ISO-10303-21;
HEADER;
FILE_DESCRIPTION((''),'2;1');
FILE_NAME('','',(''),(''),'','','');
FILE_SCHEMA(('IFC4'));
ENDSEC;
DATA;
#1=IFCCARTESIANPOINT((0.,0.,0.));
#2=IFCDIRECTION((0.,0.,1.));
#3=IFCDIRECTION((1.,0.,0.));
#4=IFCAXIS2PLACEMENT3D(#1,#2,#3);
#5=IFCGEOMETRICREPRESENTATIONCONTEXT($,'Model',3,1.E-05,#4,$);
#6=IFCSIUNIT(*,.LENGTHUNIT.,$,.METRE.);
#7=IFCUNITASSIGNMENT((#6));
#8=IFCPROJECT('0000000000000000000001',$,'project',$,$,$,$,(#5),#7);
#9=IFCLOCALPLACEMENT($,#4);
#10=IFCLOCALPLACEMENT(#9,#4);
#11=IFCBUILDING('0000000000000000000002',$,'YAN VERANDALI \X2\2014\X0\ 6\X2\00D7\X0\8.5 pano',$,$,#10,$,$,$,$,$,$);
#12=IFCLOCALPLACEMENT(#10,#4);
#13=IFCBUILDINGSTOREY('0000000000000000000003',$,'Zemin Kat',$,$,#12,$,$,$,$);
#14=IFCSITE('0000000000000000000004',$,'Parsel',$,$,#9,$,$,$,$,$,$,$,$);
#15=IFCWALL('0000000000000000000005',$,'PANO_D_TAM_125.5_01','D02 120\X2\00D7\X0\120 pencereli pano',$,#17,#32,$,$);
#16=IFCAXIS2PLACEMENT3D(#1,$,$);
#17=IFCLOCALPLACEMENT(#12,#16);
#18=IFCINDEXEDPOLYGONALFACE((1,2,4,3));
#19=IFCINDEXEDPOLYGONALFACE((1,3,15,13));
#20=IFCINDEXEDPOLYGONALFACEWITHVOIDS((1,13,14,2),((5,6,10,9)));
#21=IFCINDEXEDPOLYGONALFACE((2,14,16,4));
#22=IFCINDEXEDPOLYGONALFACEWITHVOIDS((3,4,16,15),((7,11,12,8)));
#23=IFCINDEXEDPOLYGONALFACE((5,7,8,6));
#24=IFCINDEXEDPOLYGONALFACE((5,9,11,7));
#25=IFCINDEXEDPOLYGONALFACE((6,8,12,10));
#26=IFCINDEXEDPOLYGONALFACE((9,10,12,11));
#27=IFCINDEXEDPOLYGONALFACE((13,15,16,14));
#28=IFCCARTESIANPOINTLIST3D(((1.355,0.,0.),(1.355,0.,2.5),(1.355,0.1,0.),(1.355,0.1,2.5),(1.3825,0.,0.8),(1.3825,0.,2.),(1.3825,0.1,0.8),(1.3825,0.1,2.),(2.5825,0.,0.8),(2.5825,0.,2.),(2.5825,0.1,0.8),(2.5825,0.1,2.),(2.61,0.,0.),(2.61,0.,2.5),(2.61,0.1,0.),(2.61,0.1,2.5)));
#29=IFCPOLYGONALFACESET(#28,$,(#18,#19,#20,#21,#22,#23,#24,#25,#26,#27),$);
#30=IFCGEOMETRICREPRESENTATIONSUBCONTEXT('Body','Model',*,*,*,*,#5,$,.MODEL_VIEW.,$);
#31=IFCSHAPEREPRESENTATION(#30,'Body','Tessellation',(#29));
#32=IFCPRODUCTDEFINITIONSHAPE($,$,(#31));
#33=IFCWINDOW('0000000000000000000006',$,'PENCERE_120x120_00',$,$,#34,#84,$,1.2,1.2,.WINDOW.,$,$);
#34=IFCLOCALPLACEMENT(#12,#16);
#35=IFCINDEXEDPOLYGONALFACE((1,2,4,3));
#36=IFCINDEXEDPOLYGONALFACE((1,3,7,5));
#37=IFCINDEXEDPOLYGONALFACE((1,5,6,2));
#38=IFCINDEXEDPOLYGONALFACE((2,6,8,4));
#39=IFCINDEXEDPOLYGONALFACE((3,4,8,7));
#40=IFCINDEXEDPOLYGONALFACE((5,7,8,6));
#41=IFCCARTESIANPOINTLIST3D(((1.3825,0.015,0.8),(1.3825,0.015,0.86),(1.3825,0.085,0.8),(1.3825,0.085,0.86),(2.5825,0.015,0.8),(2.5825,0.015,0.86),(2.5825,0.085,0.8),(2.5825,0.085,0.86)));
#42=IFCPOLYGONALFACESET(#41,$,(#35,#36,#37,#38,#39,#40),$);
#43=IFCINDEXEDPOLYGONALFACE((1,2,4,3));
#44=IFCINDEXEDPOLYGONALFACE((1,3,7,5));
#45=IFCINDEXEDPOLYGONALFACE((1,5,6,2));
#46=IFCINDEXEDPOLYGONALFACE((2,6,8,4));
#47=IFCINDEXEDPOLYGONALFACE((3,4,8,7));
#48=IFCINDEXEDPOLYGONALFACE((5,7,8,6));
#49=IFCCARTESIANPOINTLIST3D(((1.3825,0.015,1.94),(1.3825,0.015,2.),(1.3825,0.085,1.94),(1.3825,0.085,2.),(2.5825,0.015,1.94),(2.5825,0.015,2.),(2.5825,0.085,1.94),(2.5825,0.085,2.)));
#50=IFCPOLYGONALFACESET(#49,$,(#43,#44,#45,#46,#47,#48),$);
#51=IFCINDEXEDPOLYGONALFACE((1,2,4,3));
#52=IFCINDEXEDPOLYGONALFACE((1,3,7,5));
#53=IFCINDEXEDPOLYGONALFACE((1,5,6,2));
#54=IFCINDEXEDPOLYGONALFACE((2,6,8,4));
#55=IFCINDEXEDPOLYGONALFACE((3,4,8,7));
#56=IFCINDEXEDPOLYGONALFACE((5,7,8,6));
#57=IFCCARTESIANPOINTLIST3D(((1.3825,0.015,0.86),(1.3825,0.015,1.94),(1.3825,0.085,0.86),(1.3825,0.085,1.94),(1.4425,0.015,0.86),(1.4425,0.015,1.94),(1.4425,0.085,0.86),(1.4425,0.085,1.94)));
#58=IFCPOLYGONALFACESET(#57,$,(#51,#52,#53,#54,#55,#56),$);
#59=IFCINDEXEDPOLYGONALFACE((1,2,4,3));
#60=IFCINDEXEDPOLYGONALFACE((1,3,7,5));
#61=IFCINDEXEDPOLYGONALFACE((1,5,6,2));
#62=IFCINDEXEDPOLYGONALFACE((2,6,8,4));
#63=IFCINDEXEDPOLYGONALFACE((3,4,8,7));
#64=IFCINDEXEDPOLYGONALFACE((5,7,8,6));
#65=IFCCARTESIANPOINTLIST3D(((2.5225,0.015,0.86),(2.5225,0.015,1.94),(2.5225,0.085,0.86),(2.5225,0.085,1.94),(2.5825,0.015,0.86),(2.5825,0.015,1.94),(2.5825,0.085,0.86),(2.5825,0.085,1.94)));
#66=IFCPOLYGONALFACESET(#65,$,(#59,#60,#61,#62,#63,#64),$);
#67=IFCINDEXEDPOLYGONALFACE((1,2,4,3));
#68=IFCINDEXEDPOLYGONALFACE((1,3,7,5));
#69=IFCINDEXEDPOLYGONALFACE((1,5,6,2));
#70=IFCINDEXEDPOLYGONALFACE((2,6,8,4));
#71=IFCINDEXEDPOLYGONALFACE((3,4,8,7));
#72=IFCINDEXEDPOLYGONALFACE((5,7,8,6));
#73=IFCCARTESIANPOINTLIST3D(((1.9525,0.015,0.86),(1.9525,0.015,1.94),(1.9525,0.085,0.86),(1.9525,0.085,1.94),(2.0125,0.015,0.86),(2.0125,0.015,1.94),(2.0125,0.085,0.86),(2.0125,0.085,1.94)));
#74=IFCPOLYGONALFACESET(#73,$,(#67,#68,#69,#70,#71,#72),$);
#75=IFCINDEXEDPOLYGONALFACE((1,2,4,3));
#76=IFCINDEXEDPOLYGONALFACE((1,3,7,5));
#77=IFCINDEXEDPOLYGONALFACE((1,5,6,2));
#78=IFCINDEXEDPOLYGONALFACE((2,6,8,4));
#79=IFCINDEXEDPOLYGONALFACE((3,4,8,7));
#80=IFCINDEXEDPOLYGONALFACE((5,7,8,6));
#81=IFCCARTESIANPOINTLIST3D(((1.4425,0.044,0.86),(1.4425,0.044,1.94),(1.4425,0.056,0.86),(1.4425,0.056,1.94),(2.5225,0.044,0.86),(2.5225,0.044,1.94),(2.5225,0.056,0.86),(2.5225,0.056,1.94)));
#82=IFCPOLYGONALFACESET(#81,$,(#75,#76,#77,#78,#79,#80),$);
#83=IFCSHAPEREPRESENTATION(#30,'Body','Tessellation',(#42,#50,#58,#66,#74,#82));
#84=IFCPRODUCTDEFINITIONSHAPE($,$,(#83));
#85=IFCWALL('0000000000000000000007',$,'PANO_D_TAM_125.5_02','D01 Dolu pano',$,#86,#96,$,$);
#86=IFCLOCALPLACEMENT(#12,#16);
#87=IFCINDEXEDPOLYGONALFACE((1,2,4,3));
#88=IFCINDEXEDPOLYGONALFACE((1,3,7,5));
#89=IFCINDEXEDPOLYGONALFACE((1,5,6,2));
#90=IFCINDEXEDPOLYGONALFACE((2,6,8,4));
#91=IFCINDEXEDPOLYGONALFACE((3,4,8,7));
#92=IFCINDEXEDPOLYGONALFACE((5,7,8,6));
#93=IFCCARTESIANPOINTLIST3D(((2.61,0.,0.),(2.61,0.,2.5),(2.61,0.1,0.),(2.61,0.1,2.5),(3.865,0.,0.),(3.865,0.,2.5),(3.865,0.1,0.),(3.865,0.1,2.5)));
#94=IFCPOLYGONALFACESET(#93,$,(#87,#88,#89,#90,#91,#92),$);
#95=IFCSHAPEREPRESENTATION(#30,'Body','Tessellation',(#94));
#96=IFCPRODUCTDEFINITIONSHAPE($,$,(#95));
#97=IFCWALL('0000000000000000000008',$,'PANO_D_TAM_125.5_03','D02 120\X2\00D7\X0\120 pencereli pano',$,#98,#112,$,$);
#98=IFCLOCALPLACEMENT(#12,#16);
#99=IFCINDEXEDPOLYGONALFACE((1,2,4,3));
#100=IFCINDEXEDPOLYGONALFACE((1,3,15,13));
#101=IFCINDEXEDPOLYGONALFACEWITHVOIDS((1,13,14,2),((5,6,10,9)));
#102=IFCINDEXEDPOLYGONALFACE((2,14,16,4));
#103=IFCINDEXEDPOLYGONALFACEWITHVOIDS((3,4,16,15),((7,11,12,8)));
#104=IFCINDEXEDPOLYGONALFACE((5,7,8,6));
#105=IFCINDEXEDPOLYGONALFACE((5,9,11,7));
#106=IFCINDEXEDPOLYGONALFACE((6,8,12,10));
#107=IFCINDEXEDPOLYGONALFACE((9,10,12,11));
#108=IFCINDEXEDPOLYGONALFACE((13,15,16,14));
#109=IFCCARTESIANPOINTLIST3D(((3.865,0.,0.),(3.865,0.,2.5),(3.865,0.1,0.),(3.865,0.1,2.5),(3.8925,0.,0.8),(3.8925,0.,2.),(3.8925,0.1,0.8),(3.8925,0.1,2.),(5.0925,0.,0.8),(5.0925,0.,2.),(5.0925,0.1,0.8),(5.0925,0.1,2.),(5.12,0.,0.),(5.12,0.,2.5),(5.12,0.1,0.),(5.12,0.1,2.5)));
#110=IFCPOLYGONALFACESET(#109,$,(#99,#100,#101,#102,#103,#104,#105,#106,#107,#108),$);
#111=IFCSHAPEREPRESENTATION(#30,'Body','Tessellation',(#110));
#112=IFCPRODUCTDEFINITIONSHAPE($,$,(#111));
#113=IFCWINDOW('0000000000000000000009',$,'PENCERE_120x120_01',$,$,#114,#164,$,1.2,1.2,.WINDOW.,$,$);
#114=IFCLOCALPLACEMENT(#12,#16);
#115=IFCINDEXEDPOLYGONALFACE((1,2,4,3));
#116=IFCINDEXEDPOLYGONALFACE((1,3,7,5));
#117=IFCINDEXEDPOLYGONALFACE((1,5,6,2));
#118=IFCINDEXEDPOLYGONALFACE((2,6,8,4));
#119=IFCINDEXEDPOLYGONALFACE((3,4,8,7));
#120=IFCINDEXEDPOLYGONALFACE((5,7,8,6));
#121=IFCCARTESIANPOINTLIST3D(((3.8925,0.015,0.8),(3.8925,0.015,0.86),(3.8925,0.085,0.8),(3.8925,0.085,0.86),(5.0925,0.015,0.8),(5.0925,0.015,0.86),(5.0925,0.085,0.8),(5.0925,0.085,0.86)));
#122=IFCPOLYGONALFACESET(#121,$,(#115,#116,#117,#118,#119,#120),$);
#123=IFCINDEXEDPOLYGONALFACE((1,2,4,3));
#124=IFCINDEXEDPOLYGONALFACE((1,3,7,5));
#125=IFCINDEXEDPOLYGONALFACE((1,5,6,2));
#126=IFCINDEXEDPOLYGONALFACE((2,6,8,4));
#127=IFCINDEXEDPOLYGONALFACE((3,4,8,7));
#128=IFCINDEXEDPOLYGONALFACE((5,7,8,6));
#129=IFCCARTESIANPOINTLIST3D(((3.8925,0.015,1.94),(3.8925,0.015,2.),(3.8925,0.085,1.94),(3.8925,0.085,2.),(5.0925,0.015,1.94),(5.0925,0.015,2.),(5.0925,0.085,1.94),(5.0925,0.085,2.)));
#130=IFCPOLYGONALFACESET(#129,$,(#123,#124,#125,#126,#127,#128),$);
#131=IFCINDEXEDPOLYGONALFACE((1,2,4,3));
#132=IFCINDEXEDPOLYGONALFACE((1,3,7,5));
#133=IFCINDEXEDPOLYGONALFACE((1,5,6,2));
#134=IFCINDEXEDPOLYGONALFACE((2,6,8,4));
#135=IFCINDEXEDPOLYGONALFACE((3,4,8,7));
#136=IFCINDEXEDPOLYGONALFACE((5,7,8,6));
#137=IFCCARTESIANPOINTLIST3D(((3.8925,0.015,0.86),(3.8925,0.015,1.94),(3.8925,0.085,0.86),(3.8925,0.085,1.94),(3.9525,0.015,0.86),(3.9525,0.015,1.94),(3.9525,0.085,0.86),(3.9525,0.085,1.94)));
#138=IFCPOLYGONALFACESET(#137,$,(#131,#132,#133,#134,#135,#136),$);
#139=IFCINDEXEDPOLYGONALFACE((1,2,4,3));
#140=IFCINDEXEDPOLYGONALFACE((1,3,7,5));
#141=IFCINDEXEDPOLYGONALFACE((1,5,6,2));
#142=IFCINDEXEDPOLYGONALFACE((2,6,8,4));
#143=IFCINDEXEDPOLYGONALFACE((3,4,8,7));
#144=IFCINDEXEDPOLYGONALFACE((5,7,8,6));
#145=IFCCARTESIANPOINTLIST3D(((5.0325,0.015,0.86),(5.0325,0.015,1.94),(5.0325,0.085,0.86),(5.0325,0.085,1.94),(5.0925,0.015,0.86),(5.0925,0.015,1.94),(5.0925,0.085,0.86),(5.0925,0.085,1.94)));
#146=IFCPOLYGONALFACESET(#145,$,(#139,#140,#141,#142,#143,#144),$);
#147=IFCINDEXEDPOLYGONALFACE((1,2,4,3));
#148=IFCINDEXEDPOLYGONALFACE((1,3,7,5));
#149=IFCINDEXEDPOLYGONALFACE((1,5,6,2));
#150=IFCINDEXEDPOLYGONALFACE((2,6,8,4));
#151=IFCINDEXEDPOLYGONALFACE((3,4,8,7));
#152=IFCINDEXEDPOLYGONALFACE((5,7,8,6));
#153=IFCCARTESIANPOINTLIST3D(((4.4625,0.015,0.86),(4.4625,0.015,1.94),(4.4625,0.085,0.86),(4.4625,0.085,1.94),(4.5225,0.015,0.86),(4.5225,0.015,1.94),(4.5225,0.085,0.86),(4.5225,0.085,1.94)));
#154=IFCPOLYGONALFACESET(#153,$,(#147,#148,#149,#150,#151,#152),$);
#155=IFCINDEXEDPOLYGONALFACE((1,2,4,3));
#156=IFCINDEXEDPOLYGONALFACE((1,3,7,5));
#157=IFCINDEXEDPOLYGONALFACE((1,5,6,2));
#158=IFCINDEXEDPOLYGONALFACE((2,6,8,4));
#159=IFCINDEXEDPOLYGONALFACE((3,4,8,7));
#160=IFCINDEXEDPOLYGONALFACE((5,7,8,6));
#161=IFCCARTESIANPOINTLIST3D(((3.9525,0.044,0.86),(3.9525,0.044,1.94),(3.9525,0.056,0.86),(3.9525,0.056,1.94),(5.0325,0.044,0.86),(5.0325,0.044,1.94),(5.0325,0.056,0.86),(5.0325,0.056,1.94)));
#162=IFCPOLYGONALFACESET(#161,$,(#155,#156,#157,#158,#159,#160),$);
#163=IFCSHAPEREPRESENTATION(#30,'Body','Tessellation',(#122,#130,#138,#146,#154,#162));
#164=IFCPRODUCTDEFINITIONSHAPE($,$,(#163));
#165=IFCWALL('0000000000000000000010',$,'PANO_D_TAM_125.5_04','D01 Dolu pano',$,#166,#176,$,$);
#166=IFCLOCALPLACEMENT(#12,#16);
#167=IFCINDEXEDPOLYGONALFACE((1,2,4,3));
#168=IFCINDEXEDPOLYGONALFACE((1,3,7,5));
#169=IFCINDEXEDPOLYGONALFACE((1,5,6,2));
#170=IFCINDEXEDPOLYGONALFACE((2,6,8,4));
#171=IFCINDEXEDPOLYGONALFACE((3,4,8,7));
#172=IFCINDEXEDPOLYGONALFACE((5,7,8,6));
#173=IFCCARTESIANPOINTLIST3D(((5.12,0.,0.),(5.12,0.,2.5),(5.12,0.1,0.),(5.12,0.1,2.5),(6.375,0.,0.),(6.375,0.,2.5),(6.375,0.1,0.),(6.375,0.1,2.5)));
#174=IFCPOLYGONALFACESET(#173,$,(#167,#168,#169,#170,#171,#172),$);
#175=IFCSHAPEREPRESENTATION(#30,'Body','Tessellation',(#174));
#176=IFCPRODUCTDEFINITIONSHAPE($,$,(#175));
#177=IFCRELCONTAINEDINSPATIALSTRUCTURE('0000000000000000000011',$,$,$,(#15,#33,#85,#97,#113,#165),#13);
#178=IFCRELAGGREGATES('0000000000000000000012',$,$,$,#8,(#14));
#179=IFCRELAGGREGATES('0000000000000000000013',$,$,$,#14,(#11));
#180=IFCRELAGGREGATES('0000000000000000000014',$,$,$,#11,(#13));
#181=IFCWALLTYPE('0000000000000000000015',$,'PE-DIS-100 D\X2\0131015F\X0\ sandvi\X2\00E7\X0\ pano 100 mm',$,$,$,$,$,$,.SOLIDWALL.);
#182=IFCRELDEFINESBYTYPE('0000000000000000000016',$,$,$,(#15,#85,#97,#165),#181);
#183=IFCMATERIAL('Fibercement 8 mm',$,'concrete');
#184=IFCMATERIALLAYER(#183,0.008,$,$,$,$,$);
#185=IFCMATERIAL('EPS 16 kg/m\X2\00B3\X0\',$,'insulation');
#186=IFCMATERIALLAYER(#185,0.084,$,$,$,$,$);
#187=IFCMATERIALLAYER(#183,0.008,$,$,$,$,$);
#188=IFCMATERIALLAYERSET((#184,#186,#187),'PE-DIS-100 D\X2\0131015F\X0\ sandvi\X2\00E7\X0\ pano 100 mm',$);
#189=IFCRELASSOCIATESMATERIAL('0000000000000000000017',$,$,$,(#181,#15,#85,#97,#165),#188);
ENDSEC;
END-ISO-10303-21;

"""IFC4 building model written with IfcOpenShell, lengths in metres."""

from ifc_helpers import new_model, si_unit, frame, origin_with_axes, place, context, subcontext, project, spatial, line, indexed_curve, outline, extrude, material, layer, layer_set, layer_usage, type_object, element, fill, save


model = new_model("IFC4")

# Units and contexts
model_context = context("Model", 3, precision=1e-05, world=origin_with_axes())
body_context = subcontext(model_context, "Body", "Model", "MODEL_VIEW")
ifc_project = project(units=[si_unit("LENGTHUNIT", "METRE")], contexts=[model_context])

# Site, building, storey
site_placement = place(None, origin_with_axes())
site = spatial("IfcSite", under=ifc_project, at=site_placement, Name="Parsel")
building_placement = place(site_placement, origin_with_axes())
building = spatial("IfcBuilding", under=site, at=building_placement, Name="YAN VERANDALI — 6×8.5 pano")
storey_placement = place(building_placement, origin_with_axes())
storey = spatial("IfcBuildingStorey", under=building, at=storey_placement, Name="Zemin Kat")

# Shared definitions
ifc_material_1 = material(Name="Fibercement 8 mm", Category="concrete")
ifc_layer_1 = layer(ifc_material_1, 0.008)
ifc_material_2 = material(Name="EPS 16 kg/m³", Category="insulation")
ifc_layer_2 = layer(ifc_material_2, 0.084)
ifc_layer_3 = layer(ifc_material_1, 0.008)
ifc_layer_set = layer_set([ifc_layer_1, ifc_layer_2, ifc_layer_3], Name="PE-DIS-100 Dış sandviç pano 100 mm")
wall_type = type_object("IfcWallType", Name="PE-DIS-100 Dış sandviç pano 100 mm", PredefinedType="SOLIDWALL", material=ifc_layer_set)

# Wall, opening, window
ifc_layer_usage_1 = layer_usage(ifc_layer_set, "AXIS2", "POSITIVE", 0.0)
wall_1_placement = place(storey_placement, frame((1.355, 0.0, 0.0), z_axis=(0.0, 0.0, 1.0), x_axis=(1.0, 0.0, 0.0)))
wall_1 = element("IfcWall", 1, at=wall_1_placement, inside=storey, type_object=wall_type, material=ifc_layer_usage_1, Name="PANO_D_TAM_125.5_01", Description="D02 120×120 pencereli pano", context=body_context, shape_type="SweptSolid", body=[
    extrude(outline(indexed_curve([(0.0, 0.0), (1.255, 0.0), (1.255, 0.1), (0.0, 0.1)], segments=[line(1, 2, 3, 4, 1)])), origin_with_axes(), (0.0, 0.0, 1.0), 2.5),
])
opening_1_placement = place(wall_1_placement, origin_with_axes())
opening_1 = element("IfcOpeningElement", 2, at=opening_1_placement, cuts=wall_1, PredefinedType="OPENING", context=body_context, shape_type="SweptSolid", body=[
    extrude(outline(indexed_curve([(0.0, 0.0), (1.2, 0.0), (1.2, 0.14), (0.0, 0.14)], segments=[line(1, 2, 3, 4, 1)])), frame((0.0275, -0.02, 0.8), z_axis=(0.0, 0.0, 1.0), x_axis=(1.0, 0.0, 0.0)), (0.0, 0.0, 1.0), 1.2),
])
window_1_placement = place(storey_placement, frame((1.355, 0.0, 0.0), z_axis=(0.0, 0.0, 1.0), x_axis=(1.0, 0.0, 0.0)))
window_1 = element("IfcWindow", 3, at=window_1_placement, inside=storey, Name="PENCERE_120x120_00", OverallHeight=1.2, OverallWidth=1.2, PredefinedType="WINDOW", context=body_context, shape_type="SweptSolid", body=[
    extrude(outline(indexed_curve([(0.0, 0.0), (1.2, 0.0), (1.2, 0.07), (0.0, 0.07)], segments=[line(1, 2, 3, 4, 1)])), frame((0.0275, 0.015, 0.8), z_axis=(0.0, 0.0, 1.0), x_axis=(1.0, 0.0, 0.0)), (0.0, 0.0, 1.0), 0.06),
    extrude(outline(indexed_curve([(0.0, 0.0), (1.2, 0.0), (1.2, 0.07), (0.0, 0.07)], segments=[line(1, 2, 3, 4, 1)])), frame((0.0275, 0.015, 1.94), z_axis=(0.0, 0.0, 1.0), x_axis=(1.0, 0.0, 0.0)), (0.0, 0.0, 1.0), 0.06),
    extrude(outline(indexed_curve([(0.0, 0.0), (0.06, 0.0), (0.06, 0.07), (0.0, 0.07)], segments=[line(1, 2, 3, 4, 1)])), frame((0.0275, 0.015, 0.86), z_axis=(0.0, 0.0, 1.0), x_axis=(1.0, 0.0, 0.0)), (0.0, 0.0, 1.0), 1.08),
    extrude(outline(indexed_curve([(0.0, 0.0), (0.06, 0.0), (0.06, 0.07), (0.0, 0.07)], segments=[line(1, 2, 3, 4, 1)])), frame((1.1675, 0.015, 0.86), z_axis=(0.0, 0.0, 1.0), x_axis=(1.0, 0.0, 0.0)), (0.0, 0.0, 1.0), 1.08),
    extrude(outline(indexed_curve([(0.0, 0.0), (0.06, 0.0), (0.06, 0.07), (0.0, 0.07)], segments=[line(1, 2, 3, 4, 1)])), frame((0.5975, 0.015, 0.86), z_axis=(0.0, 0.0, 1.0), x_axis=(1.0, 0.0, 0.0)), (0.0, 0.0, 1.0), 1.08),
    extrude(outline(indexed_curve([(0.0, 0.0), (1.08, 0.0), (1.08, 0.012), (0.0, 0.012)], segments=[line(1, 2, 3, 4, 1)])), frame((0.0875, 0.044, 0.86), z_axis=(0.0, 0.0, 1.0), x_axis=(1.0, 0.0, 0.0)), (0.0, 0.0, 1.0), 1.08),
])
fill(opening_1, window_1)

# Wall
ifc_layer_usage_2 = layer_usage(ifc_layer_set, "AXIS2", "POSITIVE", 0.0)
wall_2_placement = place(storey_placement, frame((2.61, 0.0, 0.0), z_axis=(0.0, 0.0, 1.0), x_axis=(1.0, 0.0, 0.0)))
element("IfcWall", 4, at=wall_2_placement, inside=storey, type_object=wall_type, material=ifc_layer_usage_2, Name="PANO_D_TAM_125.5_02", Description="D01 Dolu pano", context=body_context, shape_type="SweptSolid", body=[
    extrude(outline(indexed_curve([(0.0, 0.0), (1.255, 0.0), (1.255, 0.1), (0.0, 0.1)], segments=[line(1, 2, 3, 4, 1)])), origin_with_axes(), (0.0, 0.0, 1.0), 2.5),
])

# Wall, opening, window
ifc_layer_usage_3 = layer_usage(ifc_layer_set, "AXIS2", "POSITIVE", 0.0)
wall_3_placement = place(storey_placement, frame((3.865, 0.0, 0.0), z_axis=(0.0, 0.0, 1.0), x_axis=(1.0, 0.0, 0.0)))
wall_3 = element("IfcWall", 5, at=wall_3_placement, inside=storey, type_object=wall_type, material=ifc_layer_usage_3, Name="PANO_D_TAM_125.5_03", Description="D02 120×120 pencereli pano", context=body_context, shape_type="SweptSolid", body=[
    extrude(outline(indexed_curve([(0.0, 0.0), (1.255, 0.0), (1.255, 0.1), (0.0, 0.1)], segments=[line(1, 2, 3, 4, 1)])), origin_with_axes(), (0.0, 0.0, 1.0), 2.5),
])
opening_2_placement = place(wall_3_placement, origin_with_axes())
opening_2 = element("IfcOpeningElement", 6, at=opening_2_placement, cuts=wall_3, PredefinedType="OPENING", context=body_context, shape_type="SweptSolid", body=[
    extrude(outline(indexed_curve([(0.0, 0.0), (1.2, 0.0), (1.2, 0.14), (0.0, 0.14)], segments=[line(1, 2, 3, 4, 1)])), frame((0.0275, -0.02, 0.8), z_axis=(0.0, 0.0, 1.0), x_axis=(1.0, 0.0, 0.0)), (0.0, 0.0, 1.0), 1.2),
])
window_2_placement = place(storey_placement, frame((3.865, 0.0, 0.0), z_axis=(0.0, 0.0, 1.0), x_axis=(1.0, 0.0, 0.0)))
window_2 = element("IfcWindow", 7, at=window_2_placement, inside=storey, Name="PENCERE_120x120_01", OverallHeight=1.2, OverallWidth=1.2, PredefinedType="WINDOW", context=body_context, shape_type="SweptSolid", body=[
    extrude(outline(indexed_curve([(0.0, 0.0), (1.2, 0.0), (1.2, 0.07), (0.0, 0.07)], segments=[line(1, 2, 3, 4, 1)])), frame((0.0275, 0.015, 0.8), z_axis=(0.0, 0.0, 1.0), x_axis=(1.0, 0.0, 0.0)), (0.0, 0.0, 1.0), 0.06),
    extrude(outline(indexed_curve([(0.0, 0.0), (1.2, 0.0), (1.2, 0.07), (0.0, 0.07)], segments=[line(1, 2, 3, 4, 1)])), frame((0.0275, 0.015, 1.94), z_axis=(0.0, 0.0, 1.0), x_axis=(1.0, 0.0, 0.0)), (0.0, 0.0, 1.0), 0.06),
    extrude(outline(indexed_curve([(0.0, 0.0), (0.06, 0.0), (0.06, 0.07), (0.0, 0.07)], segments=[line(1, 2, 3, 4, 1)])), frame((0.0275, 0.015, 0.86), z_axis=(0.0, 0.0, 1.0), x_axis=(1.0, 0.0, 0.0)), (0.0, 0.0, 1.0), 1.08),
    extrude(outline(indexed_curve([(0.0, 0.0), (0.06, 0.0), (0.06, 0.07), (0.0, 0.07)], segments=[line(1, 2, 3, 4, 1)])), frame((1.1675, 0.015, 0.86), z_axis=(0.0, 0.0, 1.0), x_axis=(1.0, 0.0, 0.0)), (0.0, 0.0, 1.0), 1.08),
    extrude(outline(indexed_curve([(0.0, 0.0), (0.06, 0.0), (0.06, 0.07), (0.0, 0.07)], segments=[line(1, 2, 3, 4, 1)])), frame((0.5975, 0.015, 0.86), z_axis=(0.0, 0.0, 1.0), x_axis=(1.0, 0.0, 0.0)), (0.0, 0.0, 1.0), 1.08),
    extrude(outline(indexed_curve([(0.0, 0.0), (1.08, 0.0), (1.08, 0.012), (0.0, 0.012)], segments=[line(1, 2, 3, 4, 1)])), frame((0.0875, 0.044, 0.86), z_axis=(0.0, 0.0, 1.0), x_axis=(1.0, 0.0, 0.0)), (0.0, 0.0, 1.0), 1.08),
])
fill(opening_2, window_2)

# Wall
ifc_layer_usage_4 = layer_usage(ifc_layer_set, "AXIS2", "POSITIVE", 0.0)
wall_4_placement = place(storey_placement, frame((5.12, 0.0, 0.0), z_axis=(0.0, 0.0, 1.0), x_axis=(1.0, 0.0, 0.0)))
element("IfcWall", 8, at=wall_4_placement, inside=storey, type_object=wall_type, material=ifc_layer_usage_4, Name="PANO_D_TAM_125.5_04", Description="D01 Dolu pano", context=body_context, shape_type="SweptSolid", body=[
    extrude(outline(indexed_curve([(0.0, 0.0), (1.255, 0.0), (1.255, 0.1), (0.0, 0.1)], segments=[line(1, 2, 3, 4, 1)])), origin_with_axes(), (0.0, 0.0, 1.0), 2.5),
])

save(model, "model.ifc")
